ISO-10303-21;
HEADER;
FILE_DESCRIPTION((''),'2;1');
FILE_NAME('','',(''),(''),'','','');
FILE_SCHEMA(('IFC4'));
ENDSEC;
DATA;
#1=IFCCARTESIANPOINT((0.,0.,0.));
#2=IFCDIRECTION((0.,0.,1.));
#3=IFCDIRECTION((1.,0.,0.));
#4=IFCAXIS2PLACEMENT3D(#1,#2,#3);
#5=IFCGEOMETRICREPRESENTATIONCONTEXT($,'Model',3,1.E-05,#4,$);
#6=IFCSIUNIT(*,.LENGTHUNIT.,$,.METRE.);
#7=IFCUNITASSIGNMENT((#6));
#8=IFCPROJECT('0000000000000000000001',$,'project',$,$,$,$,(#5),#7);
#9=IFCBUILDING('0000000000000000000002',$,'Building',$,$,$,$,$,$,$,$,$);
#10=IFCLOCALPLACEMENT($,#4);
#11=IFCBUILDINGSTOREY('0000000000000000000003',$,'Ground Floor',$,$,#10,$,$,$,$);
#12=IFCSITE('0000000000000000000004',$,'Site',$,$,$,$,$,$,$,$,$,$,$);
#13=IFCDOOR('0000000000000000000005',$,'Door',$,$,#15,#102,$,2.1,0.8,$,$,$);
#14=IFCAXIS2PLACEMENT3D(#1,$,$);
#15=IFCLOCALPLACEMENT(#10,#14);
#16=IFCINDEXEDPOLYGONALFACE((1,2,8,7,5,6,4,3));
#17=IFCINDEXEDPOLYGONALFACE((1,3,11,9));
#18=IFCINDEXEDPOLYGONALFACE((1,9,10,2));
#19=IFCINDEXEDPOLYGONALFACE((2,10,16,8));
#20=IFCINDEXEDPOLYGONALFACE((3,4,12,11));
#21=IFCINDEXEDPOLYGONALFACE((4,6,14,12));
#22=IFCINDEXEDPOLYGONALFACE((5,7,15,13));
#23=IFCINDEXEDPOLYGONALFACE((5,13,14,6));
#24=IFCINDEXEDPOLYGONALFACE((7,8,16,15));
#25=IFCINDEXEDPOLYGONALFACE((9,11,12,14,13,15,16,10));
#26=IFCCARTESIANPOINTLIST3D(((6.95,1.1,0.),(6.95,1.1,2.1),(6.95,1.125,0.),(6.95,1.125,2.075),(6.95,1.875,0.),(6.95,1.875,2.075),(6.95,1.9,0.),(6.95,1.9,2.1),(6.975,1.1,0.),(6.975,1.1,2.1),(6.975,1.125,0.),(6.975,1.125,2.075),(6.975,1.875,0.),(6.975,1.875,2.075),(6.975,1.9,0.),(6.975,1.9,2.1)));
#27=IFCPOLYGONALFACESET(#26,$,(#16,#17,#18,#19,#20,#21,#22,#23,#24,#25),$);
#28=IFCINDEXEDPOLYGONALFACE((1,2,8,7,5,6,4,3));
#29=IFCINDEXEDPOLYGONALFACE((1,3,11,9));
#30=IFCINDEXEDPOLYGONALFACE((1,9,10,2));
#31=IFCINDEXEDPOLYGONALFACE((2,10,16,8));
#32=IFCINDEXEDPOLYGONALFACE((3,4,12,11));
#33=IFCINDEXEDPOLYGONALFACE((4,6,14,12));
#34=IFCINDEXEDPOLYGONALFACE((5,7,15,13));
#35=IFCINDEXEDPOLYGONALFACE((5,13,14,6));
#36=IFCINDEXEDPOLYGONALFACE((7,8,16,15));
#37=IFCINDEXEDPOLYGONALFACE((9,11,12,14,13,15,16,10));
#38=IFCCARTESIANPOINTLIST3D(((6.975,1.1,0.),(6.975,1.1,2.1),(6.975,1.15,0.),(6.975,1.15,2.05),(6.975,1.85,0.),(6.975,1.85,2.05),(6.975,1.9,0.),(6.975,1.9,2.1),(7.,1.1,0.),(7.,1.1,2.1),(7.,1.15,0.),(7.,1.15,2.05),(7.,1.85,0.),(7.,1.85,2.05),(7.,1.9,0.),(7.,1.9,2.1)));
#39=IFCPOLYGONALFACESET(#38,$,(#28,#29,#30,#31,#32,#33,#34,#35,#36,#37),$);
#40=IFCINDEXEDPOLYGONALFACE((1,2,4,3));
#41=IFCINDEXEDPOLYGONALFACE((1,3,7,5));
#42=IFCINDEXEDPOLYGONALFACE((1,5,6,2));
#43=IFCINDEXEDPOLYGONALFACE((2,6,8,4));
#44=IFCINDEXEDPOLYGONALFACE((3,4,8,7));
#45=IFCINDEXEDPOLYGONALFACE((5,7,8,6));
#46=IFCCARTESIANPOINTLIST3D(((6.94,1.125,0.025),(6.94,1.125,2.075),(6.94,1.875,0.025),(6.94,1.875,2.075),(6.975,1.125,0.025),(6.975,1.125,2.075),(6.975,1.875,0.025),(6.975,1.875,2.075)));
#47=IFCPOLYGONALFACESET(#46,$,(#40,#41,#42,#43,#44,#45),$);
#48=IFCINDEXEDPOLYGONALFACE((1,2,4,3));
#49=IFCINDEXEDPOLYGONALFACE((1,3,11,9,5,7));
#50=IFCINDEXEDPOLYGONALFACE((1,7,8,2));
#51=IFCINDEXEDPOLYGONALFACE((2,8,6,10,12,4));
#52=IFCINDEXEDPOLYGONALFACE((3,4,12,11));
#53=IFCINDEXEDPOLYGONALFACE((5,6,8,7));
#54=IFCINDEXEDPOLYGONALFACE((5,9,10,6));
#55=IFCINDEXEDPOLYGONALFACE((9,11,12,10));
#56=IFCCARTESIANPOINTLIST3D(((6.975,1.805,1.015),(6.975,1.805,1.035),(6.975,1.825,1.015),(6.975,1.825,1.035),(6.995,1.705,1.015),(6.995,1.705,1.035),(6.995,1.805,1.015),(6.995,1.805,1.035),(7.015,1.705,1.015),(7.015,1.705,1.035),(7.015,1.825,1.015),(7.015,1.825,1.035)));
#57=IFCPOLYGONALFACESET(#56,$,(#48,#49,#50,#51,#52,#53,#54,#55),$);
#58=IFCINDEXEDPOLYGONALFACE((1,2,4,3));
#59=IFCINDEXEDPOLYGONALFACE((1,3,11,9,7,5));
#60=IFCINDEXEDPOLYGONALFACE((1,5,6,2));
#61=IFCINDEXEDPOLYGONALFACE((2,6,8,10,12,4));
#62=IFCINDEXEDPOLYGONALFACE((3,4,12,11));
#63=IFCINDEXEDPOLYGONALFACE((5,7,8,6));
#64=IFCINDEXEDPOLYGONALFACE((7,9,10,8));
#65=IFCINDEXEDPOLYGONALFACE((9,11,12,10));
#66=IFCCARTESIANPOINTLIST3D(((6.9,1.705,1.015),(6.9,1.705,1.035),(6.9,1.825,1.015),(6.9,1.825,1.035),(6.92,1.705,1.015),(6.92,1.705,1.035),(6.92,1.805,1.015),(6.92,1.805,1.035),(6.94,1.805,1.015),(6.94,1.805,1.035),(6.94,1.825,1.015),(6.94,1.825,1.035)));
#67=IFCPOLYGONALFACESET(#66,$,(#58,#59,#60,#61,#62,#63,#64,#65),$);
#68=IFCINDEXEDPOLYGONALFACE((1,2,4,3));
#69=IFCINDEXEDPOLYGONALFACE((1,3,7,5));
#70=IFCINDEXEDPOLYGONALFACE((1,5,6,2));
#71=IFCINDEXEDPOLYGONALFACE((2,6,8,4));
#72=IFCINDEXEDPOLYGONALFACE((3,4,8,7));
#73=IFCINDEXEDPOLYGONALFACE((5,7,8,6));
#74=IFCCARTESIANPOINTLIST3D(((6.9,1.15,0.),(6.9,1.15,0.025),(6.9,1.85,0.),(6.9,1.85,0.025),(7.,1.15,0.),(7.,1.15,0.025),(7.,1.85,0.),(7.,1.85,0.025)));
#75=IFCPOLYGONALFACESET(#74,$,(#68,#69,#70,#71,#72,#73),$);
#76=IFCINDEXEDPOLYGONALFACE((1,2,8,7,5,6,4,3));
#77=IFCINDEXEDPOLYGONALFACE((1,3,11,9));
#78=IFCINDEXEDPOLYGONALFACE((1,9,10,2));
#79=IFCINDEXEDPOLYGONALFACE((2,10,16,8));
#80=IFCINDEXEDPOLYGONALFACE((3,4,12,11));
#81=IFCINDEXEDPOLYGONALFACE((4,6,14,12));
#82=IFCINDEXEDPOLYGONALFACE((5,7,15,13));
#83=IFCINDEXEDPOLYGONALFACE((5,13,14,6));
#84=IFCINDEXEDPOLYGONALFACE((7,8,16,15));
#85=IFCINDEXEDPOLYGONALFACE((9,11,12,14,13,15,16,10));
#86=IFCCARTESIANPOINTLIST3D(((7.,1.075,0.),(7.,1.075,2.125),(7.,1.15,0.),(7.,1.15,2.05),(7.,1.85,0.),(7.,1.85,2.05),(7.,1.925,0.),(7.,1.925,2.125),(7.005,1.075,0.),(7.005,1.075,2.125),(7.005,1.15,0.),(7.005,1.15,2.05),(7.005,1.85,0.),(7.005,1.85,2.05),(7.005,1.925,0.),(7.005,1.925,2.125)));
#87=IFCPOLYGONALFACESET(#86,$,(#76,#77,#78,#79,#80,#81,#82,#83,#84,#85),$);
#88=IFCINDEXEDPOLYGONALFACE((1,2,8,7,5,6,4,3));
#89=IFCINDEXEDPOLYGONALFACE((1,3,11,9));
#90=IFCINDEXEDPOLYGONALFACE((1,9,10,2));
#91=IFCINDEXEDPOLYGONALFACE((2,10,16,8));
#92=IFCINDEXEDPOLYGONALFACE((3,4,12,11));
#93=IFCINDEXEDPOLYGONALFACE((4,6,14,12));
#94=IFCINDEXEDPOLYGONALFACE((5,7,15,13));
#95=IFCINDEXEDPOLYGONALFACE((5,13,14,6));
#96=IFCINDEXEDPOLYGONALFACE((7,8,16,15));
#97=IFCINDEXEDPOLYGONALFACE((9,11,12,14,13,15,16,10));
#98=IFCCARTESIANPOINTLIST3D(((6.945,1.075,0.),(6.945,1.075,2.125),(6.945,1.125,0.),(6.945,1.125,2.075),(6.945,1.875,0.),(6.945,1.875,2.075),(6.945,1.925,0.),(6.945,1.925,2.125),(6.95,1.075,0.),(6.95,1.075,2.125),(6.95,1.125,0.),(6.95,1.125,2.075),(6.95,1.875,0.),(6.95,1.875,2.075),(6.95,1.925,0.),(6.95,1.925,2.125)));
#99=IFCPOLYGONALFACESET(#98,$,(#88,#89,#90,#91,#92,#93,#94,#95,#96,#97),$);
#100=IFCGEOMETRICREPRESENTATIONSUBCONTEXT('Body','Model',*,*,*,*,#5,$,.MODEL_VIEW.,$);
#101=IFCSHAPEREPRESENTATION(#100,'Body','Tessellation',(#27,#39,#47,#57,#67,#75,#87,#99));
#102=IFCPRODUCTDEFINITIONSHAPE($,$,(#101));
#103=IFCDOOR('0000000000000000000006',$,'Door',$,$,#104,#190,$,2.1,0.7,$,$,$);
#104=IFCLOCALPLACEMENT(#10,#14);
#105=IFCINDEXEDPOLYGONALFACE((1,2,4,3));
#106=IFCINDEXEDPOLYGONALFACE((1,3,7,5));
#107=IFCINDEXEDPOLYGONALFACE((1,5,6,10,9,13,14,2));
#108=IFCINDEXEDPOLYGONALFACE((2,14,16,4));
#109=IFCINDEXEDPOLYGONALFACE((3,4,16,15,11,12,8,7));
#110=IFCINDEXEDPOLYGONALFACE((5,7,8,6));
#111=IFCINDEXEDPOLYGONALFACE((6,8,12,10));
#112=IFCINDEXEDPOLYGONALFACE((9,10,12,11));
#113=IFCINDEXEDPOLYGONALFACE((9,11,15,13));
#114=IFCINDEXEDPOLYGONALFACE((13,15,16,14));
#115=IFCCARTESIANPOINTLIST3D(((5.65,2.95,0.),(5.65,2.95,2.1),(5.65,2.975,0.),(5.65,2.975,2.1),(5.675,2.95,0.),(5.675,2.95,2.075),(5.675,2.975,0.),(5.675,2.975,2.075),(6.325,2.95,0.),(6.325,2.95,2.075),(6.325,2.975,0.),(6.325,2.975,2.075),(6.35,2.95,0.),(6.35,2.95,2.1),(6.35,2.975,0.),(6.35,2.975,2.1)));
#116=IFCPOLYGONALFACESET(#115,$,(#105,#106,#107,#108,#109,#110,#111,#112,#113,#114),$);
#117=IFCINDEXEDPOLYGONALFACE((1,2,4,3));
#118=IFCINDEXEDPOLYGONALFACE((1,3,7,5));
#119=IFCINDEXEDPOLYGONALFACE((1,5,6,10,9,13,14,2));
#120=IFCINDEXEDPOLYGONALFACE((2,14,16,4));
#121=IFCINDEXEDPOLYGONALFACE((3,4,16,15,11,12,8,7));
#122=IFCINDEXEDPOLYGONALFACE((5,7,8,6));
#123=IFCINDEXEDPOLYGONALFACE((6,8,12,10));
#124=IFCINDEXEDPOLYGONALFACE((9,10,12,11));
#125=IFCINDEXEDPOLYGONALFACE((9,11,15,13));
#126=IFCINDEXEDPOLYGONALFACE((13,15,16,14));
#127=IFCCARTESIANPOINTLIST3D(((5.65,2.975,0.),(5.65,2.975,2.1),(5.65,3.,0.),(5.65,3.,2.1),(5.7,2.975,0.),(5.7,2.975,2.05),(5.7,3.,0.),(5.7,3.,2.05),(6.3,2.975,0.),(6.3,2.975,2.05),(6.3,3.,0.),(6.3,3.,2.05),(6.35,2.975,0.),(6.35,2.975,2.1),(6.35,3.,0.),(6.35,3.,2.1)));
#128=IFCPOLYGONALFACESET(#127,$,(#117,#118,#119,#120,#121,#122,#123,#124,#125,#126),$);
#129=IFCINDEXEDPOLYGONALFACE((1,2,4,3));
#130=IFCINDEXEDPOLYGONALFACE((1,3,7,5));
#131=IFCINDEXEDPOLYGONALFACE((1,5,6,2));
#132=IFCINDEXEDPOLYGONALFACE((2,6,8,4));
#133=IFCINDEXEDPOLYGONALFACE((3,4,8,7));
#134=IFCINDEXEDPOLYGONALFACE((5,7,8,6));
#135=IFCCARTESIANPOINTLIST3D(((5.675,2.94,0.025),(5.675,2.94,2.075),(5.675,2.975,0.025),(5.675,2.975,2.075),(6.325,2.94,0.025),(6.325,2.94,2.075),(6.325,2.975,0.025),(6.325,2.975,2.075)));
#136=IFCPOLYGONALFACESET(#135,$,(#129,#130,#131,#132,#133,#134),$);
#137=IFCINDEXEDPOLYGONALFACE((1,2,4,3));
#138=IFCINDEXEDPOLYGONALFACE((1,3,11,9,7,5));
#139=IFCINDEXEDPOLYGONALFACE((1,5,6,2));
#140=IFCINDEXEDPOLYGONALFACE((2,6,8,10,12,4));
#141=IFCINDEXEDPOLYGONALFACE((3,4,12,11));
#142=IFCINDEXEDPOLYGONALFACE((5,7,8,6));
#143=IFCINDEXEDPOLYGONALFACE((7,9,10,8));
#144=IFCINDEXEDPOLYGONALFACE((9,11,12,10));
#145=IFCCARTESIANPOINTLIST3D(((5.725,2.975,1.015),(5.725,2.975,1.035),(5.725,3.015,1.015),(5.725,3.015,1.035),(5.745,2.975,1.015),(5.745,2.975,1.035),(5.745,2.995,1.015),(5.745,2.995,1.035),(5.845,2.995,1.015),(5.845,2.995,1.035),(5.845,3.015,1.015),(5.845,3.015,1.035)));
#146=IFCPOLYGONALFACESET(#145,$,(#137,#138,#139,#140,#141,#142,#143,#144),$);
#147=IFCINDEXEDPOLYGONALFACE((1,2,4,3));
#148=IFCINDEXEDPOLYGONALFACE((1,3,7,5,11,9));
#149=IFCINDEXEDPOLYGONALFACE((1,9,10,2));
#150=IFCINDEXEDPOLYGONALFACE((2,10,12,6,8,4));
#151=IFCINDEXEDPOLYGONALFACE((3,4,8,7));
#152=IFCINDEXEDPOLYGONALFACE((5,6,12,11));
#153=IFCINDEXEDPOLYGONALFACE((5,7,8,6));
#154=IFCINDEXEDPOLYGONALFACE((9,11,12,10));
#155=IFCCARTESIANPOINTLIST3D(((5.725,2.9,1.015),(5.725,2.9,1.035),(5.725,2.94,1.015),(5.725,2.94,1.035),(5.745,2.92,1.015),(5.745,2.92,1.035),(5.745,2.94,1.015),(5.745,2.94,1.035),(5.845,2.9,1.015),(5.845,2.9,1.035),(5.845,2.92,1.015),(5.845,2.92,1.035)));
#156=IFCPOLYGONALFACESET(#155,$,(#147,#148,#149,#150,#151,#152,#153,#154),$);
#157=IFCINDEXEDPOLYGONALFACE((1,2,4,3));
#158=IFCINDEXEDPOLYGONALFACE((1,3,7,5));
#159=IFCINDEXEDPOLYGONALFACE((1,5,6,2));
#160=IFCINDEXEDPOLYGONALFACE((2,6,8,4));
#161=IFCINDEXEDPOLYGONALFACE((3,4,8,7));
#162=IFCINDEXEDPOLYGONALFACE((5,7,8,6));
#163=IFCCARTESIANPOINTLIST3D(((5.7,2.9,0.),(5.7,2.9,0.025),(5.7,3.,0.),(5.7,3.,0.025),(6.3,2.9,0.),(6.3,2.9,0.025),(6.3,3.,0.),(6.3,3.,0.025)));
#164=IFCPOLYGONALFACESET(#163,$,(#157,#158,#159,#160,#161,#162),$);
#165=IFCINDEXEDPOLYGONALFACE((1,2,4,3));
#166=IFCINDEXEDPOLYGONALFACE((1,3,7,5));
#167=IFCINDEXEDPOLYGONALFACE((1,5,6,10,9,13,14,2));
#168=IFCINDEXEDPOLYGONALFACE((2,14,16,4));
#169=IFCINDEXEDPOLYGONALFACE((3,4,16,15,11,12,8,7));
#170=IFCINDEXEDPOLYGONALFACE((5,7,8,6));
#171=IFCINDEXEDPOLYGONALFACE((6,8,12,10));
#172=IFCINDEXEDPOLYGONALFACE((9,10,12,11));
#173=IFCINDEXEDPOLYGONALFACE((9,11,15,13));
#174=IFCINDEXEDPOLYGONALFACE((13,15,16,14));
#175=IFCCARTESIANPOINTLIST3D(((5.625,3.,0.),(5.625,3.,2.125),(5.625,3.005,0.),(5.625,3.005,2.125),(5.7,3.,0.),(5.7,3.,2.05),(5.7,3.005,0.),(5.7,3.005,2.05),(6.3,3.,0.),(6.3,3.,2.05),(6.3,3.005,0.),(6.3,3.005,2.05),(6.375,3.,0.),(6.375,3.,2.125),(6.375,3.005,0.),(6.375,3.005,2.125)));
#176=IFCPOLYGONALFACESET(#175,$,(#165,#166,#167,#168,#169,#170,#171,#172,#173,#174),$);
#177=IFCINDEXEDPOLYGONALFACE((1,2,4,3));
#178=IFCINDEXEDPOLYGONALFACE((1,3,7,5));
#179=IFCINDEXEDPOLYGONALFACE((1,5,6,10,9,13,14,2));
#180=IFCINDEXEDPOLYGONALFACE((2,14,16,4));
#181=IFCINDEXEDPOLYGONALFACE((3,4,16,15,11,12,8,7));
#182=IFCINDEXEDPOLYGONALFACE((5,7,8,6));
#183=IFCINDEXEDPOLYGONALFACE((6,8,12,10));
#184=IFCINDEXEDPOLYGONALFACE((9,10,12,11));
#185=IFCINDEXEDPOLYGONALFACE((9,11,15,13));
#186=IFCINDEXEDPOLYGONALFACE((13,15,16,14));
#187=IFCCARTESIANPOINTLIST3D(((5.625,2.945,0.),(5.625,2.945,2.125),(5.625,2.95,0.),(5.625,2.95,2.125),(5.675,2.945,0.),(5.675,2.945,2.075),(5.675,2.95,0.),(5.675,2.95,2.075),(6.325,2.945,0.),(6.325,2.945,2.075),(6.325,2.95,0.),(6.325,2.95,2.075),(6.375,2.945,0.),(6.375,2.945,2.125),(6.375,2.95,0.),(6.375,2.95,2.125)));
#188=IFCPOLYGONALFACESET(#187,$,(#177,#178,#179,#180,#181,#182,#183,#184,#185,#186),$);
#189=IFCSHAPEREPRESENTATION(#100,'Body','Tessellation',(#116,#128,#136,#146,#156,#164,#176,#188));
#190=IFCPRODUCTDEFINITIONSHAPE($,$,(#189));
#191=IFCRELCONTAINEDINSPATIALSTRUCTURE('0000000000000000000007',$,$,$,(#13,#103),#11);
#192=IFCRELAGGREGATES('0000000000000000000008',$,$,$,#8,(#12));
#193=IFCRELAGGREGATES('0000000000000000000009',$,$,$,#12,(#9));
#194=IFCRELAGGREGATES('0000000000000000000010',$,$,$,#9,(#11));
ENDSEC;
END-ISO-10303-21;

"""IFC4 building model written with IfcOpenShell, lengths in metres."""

from ifc_helpers import new_model, si_unit, frame, origin_with_axes, place, context, subcontext, project, spatial, line, indexed_curve, outline, extrude, element, save


model = new_model("IFC4")

# Units and contexts
model_context = context("Model", 3, precision=1e-05, world=origin_with_axes())
body_context = subcontext(model_context, "Body", "Model", "MODEL_VIEW")
ifc_project = project(units=[si_unit("LENGTHUNIT", "METRE")], contexts=[model_context])

# Site, building, storey
site = spatial("IfcSite", under=ifc_project, Name="Site")
building = spatial("IfcBuilding", under=site, Name="Building")
storey_placement = place(None, origin_with_axes())
storey = spatial("IfcBuildingStorey", under=building, at=storey_placement, Name="Ground Floor")

# Doors
door_1_placement = place(storey_placement, frame((7.0, 1.1, 0.0), z_axis=(0.0, 0.0, 1.0), x_axis=(0.0, 1.0, 0.0)))
element("IfcDoor", 1, at=door_1_placement, inside=storey, Name="Door", OverallHeight=2.1, OverallWidth=0.8, context=body_context, shape_type="SweptSolid", body=[
    extrude(outline(indexed_curve([(0.0, 0.0), (0.0, 2.1), (0.8, 2.1), (0.8, 0.0), (0.775, 0.0), (0.775, 2.075), (0.025, 2.075), (0.025, 0.0)], segments=[line(1, 2, 3, 4, 5, 6, 7, 8, 1)])), frame((0.0, 0.025, 0.0), z_axis=(0.0, -1.0, 0.0), x_axis=(1.0, 0.0, 0.0)), (0.0, 0.0, -1.0), 0.025),
    extrude(outline(indexed_curve([(0.0, 0.0), (0.0, 2.1), (0.8, 2.1), (0.8, 0.0), (0.75, 0.0), (0.75, 2.05), (0.05, 2.05), (0.05, 0.0)], segments=[line(1, 2, 3, 4, 5, 6, 7, 8, 1)])), frame((0.0, 0.0, 0.0), z_axis=(0.0, -1.0, 0.0), x_axis=(1.0, 0.0, 0.0)), (0.0, 0.0, -1.0), 0.025),
    extrude(outline(indexed_curve([(0.0, 0.0), (0.75, 0.0), (0.75, 0.035), (0.0, 0.035)], segments=[line(1, 2, 3, 4, 1)])), frame((0.025, 0.025, 0.025), z_axis=(0.0, 0.0, 1.0), x_axis=(1.0, 0.0, 0.0)), (0.0, 0.0, 1.0), 2.05),
    extrude(outline(indexed_curve([(0.0, 0.0), (0.0, -0.04), (-0.12, -0.04), (-0.12, -0.02), (-0.02, -0.02), (-0.02, 0.0)], segments=[line(1, 2, 3, 4, 5, 6, 1)])), frame((0.725, 0.025, 1.015), z_axis=(0.0, 0.0, 1.0), x_axis=(1.0, 0.0, 0.0)), (0.0, 0.0, 1.0), 0.02),
    extrude(outline(indexed_curve([(0.0, 0.0), (0.0, 0.04), (-0.12, 0.04), (-0.12, 0.02), (-0.02, 0.02), (-0.02, 0.0)], segments=[line(1, 2, 3, 4, 5, 6, 1)])), frame((0.725, 0.06, 1.015), z_axis=(0.0, 0.0, 1.0), x_axis=(1.0, 0.0, 0.0)), (0.0, 0.0, 1.0), 0.02),
    extrude(outline(indexed_curve([(0.0, 0.0), (0.7, 0.0), (0.7, 0.1), (0.0, 0.1)], segments=[line(1, 2, 3, 4, 1)])), frame((0.05, 0.0, 0.0), z_axis=(0.0, 0.0, 1.0), x_axis=(1.0, 0.0, 0.0)), (0.0, 0.0, 1.0), 0.025),
    extrude(outline(indexed_curve([(0.0, 0.0), (0.0, 2.125), (0.85, 2.125), (0.85, 0.0), (0.775, 0.0), (0.775, 2.05), (0.075, 2.05), (0.075, 0.0)], segments=[line(1, 2, 3, 4, 5, 6, 7, 8, 1)])), frame((-0.025, -0.005, 0.0), z_axis=(0.0, -1.0, 0.0), x_axis=(1.0, 0.0, 0.0)), (0.0, 0.0, -1.0), 0.005),
    extrude(outline(indexed_curve([(0.0, 0.0), (0.0, 2.125), (0.85, 2.125), (0.85, 0.0), (0.8, 0.0), (0.8, 2.075), (0.05, 2.075), (0.05, 0.0)], segments=[line(1, 2, 3, 4, 5, 6, 7, 8, 1)])), frame((-0.025, 0.05, 0.0), z_axis=(0.0, -1.0, 0.0), x_axis=(1.0, 0.0, 0.0)), (0.0, 0.0, -1.0), 0.005),
])
door_2_placement = place(storey_placement, frame((6.35, 3.0, 0.0), z_axis=(0.0, 0.0, 1.0), x_axis=(-1.0, 0.0, 0.0)))
element("IfcDoor", 2, at=door_2_placement, inside=storey, Name="Door", OverallHeight=2.1, OverallWidth=0.7, context=body_context, shape_type="SweptSolid", body=[
    extrude(outline(indexed_curve([(0.0, 0.0), (0.0, 2.1), (0.7, 2.1), (0.7, 0.0), (0.675, 0.0), (0.675, 2.075), (0.025, 2.075), (0.025, 0.0)], segments=[line(1, 2, 3, 4, 5, 6, 7, 8, 1)])), frame((0.0, 0.025, 0.0), z_axis=(0.0, -1.0, 0.0), x_axis=(1.0, 0.0, 0.0)), (0.0, 0.0, -1.0), 0.025),
    extrude(outline(indexed_curve([(0.0, 0.0), (0.0, 2.1), (0.7, 2.1), (0.7, 0.0), (0.65, 0.0), (0.65, 2.05), (0.05, 2.05), (0.05, 0.0)], segments=[line(1, 2, 3, 4, 5, 6, 7, 8, 1)])), frame((0.0, 0.0, 0.0), z_axis=(0.0, -1.0, 0.0), x_axis=(1.0, 0.0, 0.0)), (0.0, 0.0, -1.0), 0.025),
    extrude(outline(indexed_curve([(0.0, 0.0), (0.65, 0.0), (0.65, 0.035), (0.0, 0.035)], segments=[line(1, 2, 3, 4, 1)])), frame((0.025, 0.025, 0.025), z_axis=(0.0, 0.0, 1.0), x_axis=(1.0, 0.0, 0.0)), (0.0, 0.0, 1.0), 2.05),
    extrude(outline(indexed_curve([(0.0, 0.0), (0.0, -0.04), (-0.12, -0.04), (-0.12, -0.02), (-0.02, -0.02), (-0.02, 0.0)], segments=[line(1, 2, 3, 4, 5, 6, 1)])), frame((0.625, 0.025, 1.015), z_axis=(0.0, 0.0, 1.0), x_axis=(1.0, 0.0, 0.0)), (0.0, 0.0, 1.0), 0.02),
    extrude(outline(indexed_curve([(0.0, 0.0), (0.0, 0.04), (-0.12, 0.04), (-0.12, 0.02), (-0.02, 0.02), (-0.02, 0.0)], segments=[line(1, 2, 3, 4, 5, 6, 1)])), frame((0.625, 0.06, 1.015), z_axis=(0.0, 0.0, 1.0), x_axis=(1.0, 0.0, 0.0)), (0.0, 0.0, 1.0), 0.02),
    extrude(outline(indexed_curve([(0.0, 0.0), (0.6, 0.0), (0.6, 0.1), (0.0, 0.1)], segments=[line(1, 2, 3, 4, 1)])), frame((0.05, 0.0, 0.0), z_axis=(0.0, 0.0, 1.0), x_axis=(1.0, 0.0, 0.0)), (0.0, 0.0, 1.0), 0.025),
    extrude(outline(indexed_curve([(0.0, 0.0), (0.0, 2.125), (0.75, 2.125), (0.75, 0.0), (0.675, 0.0), (0.675, 2.05), (0.075, 2.05), (0.075, 0.0)], segments=[line(1, 2, 3, 4, 5, 6, 7, 8, 1)])), frame((-0.025, -0.005, 0.0), z_axis=(0.0, -1.0, 0.0), x_axis=(1.0, 0.0, 0.0)), (0.0, 0.0, -1.0), 0.005),
    extrude(outline(indexed_curve([(0.0, 0.0), (0.0, 2.125), (0.75, 2.125), (0.75, 0.0), (0.7, 0.0), (0.7, 2.075), (0.05, 2.075), (0.05, 0.0)], segments=[line(1, 2, 3, 4, 5, 6, 7, 8, 1)])), frame((-0.025, 0.05, 0.0), z_axis=(0.0, -1.0, 0.0), x_axis=(1.0, 0.0, 0.0)), (0.0, 0.0, -1.0), 0.005),
])

save(model, "model.ifc")
